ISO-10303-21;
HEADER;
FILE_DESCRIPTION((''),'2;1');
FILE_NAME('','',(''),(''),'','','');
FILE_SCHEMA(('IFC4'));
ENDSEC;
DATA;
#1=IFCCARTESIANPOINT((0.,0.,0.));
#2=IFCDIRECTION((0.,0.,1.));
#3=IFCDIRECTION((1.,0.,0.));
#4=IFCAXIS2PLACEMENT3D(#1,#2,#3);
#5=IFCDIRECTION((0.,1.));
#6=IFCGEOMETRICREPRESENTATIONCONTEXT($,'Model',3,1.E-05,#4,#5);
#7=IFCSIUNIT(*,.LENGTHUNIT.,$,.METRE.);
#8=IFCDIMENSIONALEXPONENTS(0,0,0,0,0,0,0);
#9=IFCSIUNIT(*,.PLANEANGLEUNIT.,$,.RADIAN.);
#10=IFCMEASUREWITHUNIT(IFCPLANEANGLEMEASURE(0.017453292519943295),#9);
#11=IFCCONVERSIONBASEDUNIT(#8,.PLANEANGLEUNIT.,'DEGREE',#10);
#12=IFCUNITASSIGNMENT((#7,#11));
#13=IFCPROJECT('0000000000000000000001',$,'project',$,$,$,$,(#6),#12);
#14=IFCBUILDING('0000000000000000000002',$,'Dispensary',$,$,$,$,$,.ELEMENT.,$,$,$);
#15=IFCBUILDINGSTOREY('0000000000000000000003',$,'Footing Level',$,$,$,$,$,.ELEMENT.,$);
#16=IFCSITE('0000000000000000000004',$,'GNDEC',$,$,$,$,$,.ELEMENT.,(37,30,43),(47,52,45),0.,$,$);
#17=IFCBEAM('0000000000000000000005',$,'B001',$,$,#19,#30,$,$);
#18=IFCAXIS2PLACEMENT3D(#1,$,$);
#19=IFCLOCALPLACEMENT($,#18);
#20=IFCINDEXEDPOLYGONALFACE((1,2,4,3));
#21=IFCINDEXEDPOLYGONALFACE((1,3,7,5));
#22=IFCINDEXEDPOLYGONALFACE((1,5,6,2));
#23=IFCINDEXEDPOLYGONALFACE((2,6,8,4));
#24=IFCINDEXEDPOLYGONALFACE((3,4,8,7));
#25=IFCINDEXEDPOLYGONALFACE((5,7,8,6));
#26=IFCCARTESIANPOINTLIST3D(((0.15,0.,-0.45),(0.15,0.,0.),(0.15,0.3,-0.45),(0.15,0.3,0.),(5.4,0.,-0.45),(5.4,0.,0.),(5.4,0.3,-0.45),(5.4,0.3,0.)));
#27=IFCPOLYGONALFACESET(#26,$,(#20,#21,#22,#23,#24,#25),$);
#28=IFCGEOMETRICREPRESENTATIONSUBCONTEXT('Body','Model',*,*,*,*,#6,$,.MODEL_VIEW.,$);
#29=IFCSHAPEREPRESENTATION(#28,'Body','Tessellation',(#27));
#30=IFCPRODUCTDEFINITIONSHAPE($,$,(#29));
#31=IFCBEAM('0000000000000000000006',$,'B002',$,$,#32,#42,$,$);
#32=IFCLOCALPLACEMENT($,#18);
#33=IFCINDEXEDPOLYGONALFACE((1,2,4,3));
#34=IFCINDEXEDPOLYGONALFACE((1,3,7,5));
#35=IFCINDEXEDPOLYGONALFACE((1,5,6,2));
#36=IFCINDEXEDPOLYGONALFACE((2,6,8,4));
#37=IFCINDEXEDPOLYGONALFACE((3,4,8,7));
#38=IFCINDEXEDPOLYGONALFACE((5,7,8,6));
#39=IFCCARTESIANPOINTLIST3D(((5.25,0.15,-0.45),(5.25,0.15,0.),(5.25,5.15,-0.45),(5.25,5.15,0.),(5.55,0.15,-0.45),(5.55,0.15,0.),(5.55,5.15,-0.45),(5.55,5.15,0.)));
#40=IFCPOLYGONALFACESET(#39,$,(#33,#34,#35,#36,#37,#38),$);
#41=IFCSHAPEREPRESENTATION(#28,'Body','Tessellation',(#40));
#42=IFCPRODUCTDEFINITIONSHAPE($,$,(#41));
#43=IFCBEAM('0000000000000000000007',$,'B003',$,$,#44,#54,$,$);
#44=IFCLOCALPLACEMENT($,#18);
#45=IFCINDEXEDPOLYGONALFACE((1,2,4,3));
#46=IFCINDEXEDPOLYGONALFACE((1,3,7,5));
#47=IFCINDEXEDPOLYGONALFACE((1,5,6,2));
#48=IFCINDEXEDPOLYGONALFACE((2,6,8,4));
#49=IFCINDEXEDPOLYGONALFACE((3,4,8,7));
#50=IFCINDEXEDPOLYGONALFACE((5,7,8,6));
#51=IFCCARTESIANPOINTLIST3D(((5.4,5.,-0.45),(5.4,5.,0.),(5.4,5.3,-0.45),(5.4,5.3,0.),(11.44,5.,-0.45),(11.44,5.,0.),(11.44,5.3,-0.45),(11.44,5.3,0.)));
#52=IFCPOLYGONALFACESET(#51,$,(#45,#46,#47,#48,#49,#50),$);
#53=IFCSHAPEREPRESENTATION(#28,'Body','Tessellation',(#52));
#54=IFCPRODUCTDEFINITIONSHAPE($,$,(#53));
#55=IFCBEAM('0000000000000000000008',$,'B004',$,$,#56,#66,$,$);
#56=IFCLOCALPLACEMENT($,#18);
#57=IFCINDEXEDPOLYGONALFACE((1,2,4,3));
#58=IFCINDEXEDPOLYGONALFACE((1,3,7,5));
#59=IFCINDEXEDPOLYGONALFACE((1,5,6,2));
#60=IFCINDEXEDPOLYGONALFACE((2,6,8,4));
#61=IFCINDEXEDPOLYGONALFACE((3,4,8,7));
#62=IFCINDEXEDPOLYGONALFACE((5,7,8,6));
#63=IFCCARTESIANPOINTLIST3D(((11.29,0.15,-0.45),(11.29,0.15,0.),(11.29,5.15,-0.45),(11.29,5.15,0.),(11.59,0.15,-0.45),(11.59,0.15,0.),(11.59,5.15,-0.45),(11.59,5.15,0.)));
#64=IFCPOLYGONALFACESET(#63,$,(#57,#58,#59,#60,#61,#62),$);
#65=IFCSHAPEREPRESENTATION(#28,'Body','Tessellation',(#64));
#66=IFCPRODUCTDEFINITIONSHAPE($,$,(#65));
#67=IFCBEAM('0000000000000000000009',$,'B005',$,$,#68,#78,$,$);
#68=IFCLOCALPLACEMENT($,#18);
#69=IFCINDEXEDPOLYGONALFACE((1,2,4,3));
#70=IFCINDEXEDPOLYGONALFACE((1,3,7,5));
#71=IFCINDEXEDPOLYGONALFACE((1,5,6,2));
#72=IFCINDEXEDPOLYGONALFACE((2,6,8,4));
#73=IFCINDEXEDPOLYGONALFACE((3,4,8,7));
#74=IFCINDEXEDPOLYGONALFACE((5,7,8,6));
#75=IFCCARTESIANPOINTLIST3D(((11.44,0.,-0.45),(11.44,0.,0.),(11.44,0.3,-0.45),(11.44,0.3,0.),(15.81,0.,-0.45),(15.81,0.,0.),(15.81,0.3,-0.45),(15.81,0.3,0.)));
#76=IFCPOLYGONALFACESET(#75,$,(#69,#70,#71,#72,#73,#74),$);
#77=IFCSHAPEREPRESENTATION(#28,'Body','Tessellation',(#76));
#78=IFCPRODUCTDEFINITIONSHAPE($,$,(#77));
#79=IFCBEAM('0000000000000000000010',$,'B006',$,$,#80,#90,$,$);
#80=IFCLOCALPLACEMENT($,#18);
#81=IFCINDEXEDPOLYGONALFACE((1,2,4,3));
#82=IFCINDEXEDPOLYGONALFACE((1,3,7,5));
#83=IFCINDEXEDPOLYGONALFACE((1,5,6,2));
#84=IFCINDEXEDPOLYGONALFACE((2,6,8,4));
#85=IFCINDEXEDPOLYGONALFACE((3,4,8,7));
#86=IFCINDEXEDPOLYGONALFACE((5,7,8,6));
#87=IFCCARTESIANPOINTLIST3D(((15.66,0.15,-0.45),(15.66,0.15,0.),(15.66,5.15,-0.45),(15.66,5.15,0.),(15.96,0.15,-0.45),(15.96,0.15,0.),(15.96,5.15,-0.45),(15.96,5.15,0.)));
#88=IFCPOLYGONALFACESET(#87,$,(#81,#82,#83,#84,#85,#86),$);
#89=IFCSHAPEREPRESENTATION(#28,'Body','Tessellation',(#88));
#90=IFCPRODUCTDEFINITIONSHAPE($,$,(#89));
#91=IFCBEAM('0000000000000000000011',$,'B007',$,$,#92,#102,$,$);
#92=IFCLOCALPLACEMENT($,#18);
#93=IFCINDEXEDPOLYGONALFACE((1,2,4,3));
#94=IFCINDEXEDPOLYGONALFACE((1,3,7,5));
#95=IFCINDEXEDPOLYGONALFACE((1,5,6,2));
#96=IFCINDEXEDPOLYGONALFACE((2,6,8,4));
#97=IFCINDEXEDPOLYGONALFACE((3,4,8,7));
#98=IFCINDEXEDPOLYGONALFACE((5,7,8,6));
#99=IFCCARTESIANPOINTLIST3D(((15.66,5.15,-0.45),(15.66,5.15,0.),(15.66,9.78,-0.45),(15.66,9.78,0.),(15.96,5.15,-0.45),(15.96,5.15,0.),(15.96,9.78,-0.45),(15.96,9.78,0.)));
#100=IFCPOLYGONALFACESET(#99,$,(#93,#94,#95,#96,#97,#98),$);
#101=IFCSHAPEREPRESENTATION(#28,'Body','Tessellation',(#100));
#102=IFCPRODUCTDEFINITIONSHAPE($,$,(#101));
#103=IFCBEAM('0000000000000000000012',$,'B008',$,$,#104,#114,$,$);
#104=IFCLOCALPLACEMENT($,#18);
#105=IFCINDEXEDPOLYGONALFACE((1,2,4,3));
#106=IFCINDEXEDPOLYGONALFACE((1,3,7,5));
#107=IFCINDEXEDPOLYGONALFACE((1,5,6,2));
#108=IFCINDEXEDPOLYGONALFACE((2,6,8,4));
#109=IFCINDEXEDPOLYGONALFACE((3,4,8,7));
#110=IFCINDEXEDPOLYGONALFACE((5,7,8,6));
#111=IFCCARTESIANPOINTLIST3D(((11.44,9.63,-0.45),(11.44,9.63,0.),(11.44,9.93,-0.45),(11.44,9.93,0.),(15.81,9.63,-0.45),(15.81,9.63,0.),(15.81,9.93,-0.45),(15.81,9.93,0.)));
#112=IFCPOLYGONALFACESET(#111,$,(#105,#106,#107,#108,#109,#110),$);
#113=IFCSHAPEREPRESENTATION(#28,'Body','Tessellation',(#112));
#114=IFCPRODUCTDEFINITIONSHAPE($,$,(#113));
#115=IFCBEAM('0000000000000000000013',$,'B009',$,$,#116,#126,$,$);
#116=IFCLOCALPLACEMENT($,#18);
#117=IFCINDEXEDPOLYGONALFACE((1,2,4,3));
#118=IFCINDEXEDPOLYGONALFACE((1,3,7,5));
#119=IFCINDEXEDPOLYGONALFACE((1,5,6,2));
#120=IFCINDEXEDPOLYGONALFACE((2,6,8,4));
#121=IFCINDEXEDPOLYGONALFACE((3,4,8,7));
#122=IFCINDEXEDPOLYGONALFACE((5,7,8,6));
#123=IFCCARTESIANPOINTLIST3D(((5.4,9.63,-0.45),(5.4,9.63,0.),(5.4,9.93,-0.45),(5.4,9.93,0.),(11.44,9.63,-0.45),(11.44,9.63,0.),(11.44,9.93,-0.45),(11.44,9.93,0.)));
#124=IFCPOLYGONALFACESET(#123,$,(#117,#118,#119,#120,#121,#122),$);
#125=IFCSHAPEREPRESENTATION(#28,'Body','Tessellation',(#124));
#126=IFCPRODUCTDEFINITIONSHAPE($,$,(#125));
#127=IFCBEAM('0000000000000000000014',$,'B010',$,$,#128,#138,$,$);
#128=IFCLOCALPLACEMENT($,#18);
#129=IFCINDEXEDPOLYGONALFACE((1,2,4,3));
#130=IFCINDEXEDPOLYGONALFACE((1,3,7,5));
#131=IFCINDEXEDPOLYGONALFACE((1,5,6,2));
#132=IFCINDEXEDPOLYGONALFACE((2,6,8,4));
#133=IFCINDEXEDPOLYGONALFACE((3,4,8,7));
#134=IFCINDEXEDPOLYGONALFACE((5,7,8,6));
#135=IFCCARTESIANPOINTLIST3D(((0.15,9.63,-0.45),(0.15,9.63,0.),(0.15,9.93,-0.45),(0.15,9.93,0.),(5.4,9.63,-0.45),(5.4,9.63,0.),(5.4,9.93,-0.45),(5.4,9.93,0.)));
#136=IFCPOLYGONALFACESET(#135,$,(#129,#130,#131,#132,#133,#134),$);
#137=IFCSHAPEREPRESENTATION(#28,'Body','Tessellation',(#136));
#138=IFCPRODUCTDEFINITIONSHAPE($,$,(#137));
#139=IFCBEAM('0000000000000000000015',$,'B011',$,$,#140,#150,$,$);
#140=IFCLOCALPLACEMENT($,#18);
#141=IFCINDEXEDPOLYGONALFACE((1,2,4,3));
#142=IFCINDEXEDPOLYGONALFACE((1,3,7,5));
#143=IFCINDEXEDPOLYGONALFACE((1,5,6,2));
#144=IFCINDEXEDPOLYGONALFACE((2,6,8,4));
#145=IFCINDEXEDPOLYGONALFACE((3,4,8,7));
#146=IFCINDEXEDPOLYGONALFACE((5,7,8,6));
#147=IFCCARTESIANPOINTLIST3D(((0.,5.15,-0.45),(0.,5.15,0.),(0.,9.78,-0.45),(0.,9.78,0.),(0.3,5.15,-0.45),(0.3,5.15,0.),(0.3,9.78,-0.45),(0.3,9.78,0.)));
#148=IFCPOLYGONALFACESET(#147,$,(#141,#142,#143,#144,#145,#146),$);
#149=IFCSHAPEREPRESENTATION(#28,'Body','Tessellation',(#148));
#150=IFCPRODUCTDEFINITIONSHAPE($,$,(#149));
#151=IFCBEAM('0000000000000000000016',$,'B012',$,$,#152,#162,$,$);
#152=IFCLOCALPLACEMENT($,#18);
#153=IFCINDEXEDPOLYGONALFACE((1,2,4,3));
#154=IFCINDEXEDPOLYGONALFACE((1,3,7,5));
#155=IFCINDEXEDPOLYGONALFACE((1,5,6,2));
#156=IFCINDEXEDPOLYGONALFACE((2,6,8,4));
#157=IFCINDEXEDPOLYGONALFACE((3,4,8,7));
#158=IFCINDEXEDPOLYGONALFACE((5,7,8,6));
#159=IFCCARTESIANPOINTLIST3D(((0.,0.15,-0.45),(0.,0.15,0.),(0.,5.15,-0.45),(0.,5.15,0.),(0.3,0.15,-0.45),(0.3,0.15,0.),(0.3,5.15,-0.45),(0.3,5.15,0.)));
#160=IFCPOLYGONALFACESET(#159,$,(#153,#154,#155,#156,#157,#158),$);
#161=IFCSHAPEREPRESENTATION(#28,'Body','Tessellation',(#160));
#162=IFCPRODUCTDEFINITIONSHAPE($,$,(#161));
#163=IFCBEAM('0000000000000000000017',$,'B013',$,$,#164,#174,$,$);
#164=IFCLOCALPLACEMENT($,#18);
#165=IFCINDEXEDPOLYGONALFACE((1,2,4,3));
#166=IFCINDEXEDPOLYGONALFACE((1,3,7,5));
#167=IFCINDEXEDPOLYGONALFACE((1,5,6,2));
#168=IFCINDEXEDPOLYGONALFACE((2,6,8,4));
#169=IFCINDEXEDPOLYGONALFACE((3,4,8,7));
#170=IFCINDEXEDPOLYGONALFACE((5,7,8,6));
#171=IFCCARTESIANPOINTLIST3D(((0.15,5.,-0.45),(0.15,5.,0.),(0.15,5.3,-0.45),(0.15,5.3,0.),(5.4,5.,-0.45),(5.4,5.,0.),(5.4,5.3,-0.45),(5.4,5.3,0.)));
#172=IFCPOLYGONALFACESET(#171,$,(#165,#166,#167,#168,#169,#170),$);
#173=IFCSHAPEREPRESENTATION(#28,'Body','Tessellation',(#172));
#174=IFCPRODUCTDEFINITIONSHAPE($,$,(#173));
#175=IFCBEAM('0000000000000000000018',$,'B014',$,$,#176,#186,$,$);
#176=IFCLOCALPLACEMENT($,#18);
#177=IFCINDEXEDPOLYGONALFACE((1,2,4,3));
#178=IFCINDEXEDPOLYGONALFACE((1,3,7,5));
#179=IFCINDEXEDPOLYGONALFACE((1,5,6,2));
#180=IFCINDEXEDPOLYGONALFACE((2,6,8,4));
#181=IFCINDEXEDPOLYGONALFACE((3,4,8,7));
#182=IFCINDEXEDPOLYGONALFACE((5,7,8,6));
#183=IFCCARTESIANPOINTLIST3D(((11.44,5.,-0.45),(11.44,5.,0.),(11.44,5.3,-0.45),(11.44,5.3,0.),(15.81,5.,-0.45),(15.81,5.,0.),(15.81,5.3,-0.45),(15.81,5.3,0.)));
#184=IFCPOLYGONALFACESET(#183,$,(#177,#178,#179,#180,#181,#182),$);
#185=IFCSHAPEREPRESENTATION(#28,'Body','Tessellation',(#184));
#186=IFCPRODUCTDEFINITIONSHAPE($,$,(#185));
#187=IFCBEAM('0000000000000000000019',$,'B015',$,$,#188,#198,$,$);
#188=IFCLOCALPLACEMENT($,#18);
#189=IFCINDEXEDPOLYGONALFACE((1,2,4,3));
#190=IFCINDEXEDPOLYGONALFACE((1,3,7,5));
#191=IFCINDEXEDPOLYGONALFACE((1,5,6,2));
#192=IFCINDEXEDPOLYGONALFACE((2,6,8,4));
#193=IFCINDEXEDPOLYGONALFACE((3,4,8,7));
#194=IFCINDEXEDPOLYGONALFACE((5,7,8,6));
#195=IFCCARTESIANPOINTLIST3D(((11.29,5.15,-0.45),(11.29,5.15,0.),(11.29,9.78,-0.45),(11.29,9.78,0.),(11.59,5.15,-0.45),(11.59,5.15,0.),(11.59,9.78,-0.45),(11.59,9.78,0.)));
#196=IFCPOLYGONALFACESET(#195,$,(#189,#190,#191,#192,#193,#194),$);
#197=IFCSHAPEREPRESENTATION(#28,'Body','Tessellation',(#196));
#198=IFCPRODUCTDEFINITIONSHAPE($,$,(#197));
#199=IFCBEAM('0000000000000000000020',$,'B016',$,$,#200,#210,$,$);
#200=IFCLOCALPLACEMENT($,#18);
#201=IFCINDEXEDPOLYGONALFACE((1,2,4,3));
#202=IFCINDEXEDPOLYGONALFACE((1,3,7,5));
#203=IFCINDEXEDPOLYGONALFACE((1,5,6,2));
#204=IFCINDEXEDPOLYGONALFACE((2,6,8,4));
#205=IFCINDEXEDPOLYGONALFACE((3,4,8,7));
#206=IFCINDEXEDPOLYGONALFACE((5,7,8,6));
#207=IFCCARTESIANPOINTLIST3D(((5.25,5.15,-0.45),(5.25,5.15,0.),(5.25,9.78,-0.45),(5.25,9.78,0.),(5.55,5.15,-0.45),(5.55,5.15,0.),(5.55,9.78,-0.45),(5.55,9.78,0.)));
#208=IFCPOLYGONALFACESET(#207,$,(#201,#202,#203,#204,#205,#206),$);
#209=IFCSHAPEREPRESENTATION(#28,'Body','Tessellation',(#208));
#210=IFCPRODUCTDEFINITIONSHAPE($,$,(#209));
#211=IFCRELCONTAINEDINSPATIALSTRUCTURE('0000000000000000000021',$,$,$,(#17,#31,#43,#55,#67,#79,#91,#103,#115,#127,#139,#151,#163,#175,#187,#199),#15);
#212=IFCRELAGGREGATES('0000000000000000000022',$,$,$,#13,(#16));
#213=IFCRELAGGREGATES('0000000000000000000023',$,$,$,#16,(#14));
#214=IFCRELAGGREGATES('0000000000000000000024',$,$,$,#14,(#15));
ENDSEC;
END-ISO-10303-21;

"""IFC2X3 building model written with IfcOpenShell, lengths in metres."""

from ifc_helpers import new_model, entity, si_unit, converted_unit, direction, frame, frame_2d, origin_with_axes, place, context, subcontext, project, spatial, rectangle, extrude, element, save


model = new_model("IFC2X3")

# Units and contexts
model_context = context("Model", 3, precision=1e-05, world=origin_with_axes(), true_north=direction((0.0, 1.0)))
body_context = subcontext(model_context, "Body", "Model", "MODEL_VIEW")
ifc_project = project(units=[si_unit("LENGTHUNIT", "METRE"), converted_unit("PLANEANGLEUNIT", "DEGREE", entity("IfcPlaneAngleMeasure", 0.017453292519943295), si_unit("PLANEANGLEUNIT", "RADIAN"), dimensions=[0, 0, 0, 0, 0, 0, 0])], contexts=[model_context])

# Site, building, storey
site = spatial("IfcSite", under=ifc_project, Name="GNDEC", CompositionType="ELEMENT", RefLatitude=(37, 30, 43), RefLongitude=(47, 52, 45), RefElevation=0.0)
building = spatial("IfcBuilding", under=site, Name="Dispensary", CompositionType="ELEMENT")
storey = spatial("IfcBuildingStorey", under=building, Name="Footing Level", CompositionType="ELEMENT")

# Beams
placement = place(None, origin_with_axes())
element("IfcBeam", 1, at=placement, inside=storey, Name="B001", context=body_context, shape_type="SweptSolid", body=[
    extrude(rectangle(XDim=0.3, YDim=0.45, at=frame_2d((0.0, 0.0), x_axis=(0.0, 1.0))), frame((0.15, 0.15, -0.225), z_axis=(1.0, 0.0, 0.0), x_axis=(0.0, 0.0, -1.0)), (0.0, 0.0, 1.0), 5.25),
])
element("IfcBeam", 2, at=placement, inside=storey, Name="B002", context=body_context, shape_type="SweptSolid", body=[
    extrude(rectangle(XDim=0.3, YDim=0.45, at=frame_2d((0.0, 0.0), x_axis=(0.0, 1.0))), frame((5.4, 0.15, -0.225), z_axis=(0.0, 1.0, 0.0), x_axis=(0.0, 0.0, -1.0)), (0.0, 0.0, 1.0), 5.0),
])
element("IfcBeam", 3, at=placement, inside=storey, Name="B003", context=body_context, shape_type="SweptSolid", body=[
    extrude(rectangle(XDim=0.3, YDim=0.45, at=frame_2d((0.0, 0.0), x_axis=(0.0, 1.0))), frame((5.4, 5.15, -0.225), z_axis=(1.0, 0.0, 0.0), x_axis=(0.0, 0.0, -1.0)), (0.0, 0.0, 1.0), 6.04),
])
element("IfcBeam", 4, at=placement, inside=storey, Name="B004", context=body_context, shape_type="SweptSolid", body=[
    extrude(rectangle(XDim=0.3, YDim=0.45, at=frame_2d((0.0, 0.0), x_axis=(0.0, 1.0))), frame((11.44, 5.15, -0.225), z_axis=(0.0, -1.0, 0.0), x_axis=(0.0, 0.0, -1.0)), (0.0, 0.0, 1.0), 5.0),
])
element("IfcBeam", 5, at=placement, inside=storey, Name="B005", context=body_context, shape_type="SweptSolid", body=[
    extrude(rectangle(XDim=0.3, YDim=0.45, at=frame_2d((0.0, 0.0), x_axis=(0.0, 1.0))), frame((11.44, 0.15, -0.225), z_axis=(1.0, 0.0, 0.0), x_axis=(0.0, 0.0, -1.0)), (0.0, 0.0, 1.0), 4.37),
])
element("IfcBeam", 6, at=placement, inside=storey, Name="B006", context=body_context, shape_type="SweptSolid", body=[
    extrude(rectangle(XDim=0.3, YDim=0.45, at=frame_2d((0.0, 0.0), x_axis=(0.0, 1.0))), frame((15.81, 0.15, -0.225), z_axis=(0.0, 1.0, 0.0), x_axis=(0.0, 0.0, -1.0)), (0.0, 0.0, 1.0), 5.0),
])
element("IfcBeam", 7, at=placement, inside=storey, Name="B007", context=body_context, shape_type="SweptSolid", body=[
    extrude(rectangle(XDim=0.3, YDim=0.45, at=frame_2d((0.0, 0.0), x_axis=(0.0, 1.0))), frame((15.81, 5.15, -0.225), z_axis=(0.0, 1.0, 0.0), x_axis=(0.0, 0.0, -1.0)), (0.0, 0.0, 1.0), 4.63),
])
element("IfcBeam", 8, at=placement, inside=storey, Name="B008", context=body_context, shape_type="SweptSolid", body=[
    extrude(rectangle(XDim=0.3, YDim=0.45, at=frame_2d((0.0, 0.0), x_axis=(0.0, 1.0))), frame((15.81, 9.78, -0.225), z_axis=(-1.0, 0.0, 0.0), x_axis=(0.0, 0.0, -1.0)), (0.0, 0.0, 1.0), 4.37),
])
element("IfcBeam", 9, at=placement, inside=storey, Name="B009", context=body_context, shape_type="SweptSolid", body=[
    extrude(rectangle(XDim=0.3, YDim=0.45, at=frame_2d((0.0, 0.0), x_axis=(0.0, 1.0))), frame((11.44, 9.78, -0.225), z_axis=(-1.0, 0.0, 0.0), x_axis=(0.0, 0.0, -1.0)), (0.0, 0.0, 1.0), 6.04),
])
element("IfcBeam", 10, at=placement, inside=storey, Name="B010", context=body_context, shape_type="SweptSolid", body=[
    extrude(rectangle(XDim=0.3, YDim=0.45, at=frame_2d((0.0, 0.0), x_axis=(0.0, 1.0))), frame((5.4, 9.78, -0.225), z_axis=(-1.0, 0.0, 0.0), x_axis=(0.0, 0.0, -1.0)), (0.0, 0.0, 1.0), 5.25),
])
element("IfcBeam", 11, at=placement, inside=storey, Name="B011", context=body_context, shape_type="SweptSolid", body=[
    extrude(rectangle(XDim=0.3, YDim=0.45, at=frame_2d((0.0, 0.0), x_axis=(0.0, 1.0))), frame((0.15, 9.78, -0.225), z_axis=(0.0, -1.0, 0.0), x_axis=(0.0, 0.0, -1.0)), (0.0, 0.0, 1.0), 4.63),
])
element("IfcBeam", 12, at=placement, inside=storey, Name="B012", context=body_context, shape_type="SweptSolid", body=[
    extrude(rectangle(XDim=0.3, YDim=0.45, at=frame_2d((0.0, 0.0), x_axis=(0.0, 1.0))), frame((0.15, 5.15, -0.225), z_axis=(0.0, -1.0, 0.0), x_axis=(0.0, 0.0, -1.0)), (0.0, 0.0, 1.0), 5.0),
])
element("IfcBeam", 13, at=placement, inside=storey, Name="B013", context=body_context, shape_type="SweptSolid", body=[
    extrude(rectangle(XDim=0.3, YDim=0.45, at=frame_2d((0.0, 0.0), x_axis=(0.0, 1.0))), frame((0.15, 5.15, -0.225), z_axis=(1.0, 0.0, 0.0), x_axis=(0.0, 0.0, -1.0)), (0.0, 0.0, 1.0), 5.25),
])
element("IfcBeam", 14, at=placement, inside=storey, Name="B014", context=body_context, shape_type="SweptSolid", body=[
    extrude(rectangle(XDim=0.3, YDim=0.45, at=frame_2d((0.0, 0.0), x_axis=(0.0, 1.0))), frame((15.81, 5.15, -0.225), z_axis=(-1.0, 0.0, 0.0), x_axis=(0.0, 0.0, -1.0)), (0.0, 0.0, 1.0), 4.37),
])
element("IfcBeam", 15, at=placement, inside=storey, Name="B015", context=body_context, shape_type="SweptSolid", body=[
    extrude(rectangle(XDim=0.3, YDim=0.45, at=frame_2d((0.0, 0.0), x_axis=(0.0, 1.0))), frame((11.44, 5.15, -0.225), z_axis=(0.0, 1.0, 0.0), x_axis=(0.0, 0.0, -1.0)), (0.0, 0.0, 1.0), 4.63),
])
element("IfcBeam", 16, at=placement, inside=storey, Name="B016", context=body_context, shape_type="SweptSolid", body=[
    extrude(rectangle(XDim=0.3, YDim=0.45, at=frame_2d((0.0, 0.0), x_axis=(0.0, 1.0))), frame((5.4, 5.15, -0.225), z_axis=(0.0, 1.0, 0.0), x_axis=(0.0, 0.0, -1.0)), (0.0, 0.0, 1.0), 4.63),
])

save(model, "model.ifc")
